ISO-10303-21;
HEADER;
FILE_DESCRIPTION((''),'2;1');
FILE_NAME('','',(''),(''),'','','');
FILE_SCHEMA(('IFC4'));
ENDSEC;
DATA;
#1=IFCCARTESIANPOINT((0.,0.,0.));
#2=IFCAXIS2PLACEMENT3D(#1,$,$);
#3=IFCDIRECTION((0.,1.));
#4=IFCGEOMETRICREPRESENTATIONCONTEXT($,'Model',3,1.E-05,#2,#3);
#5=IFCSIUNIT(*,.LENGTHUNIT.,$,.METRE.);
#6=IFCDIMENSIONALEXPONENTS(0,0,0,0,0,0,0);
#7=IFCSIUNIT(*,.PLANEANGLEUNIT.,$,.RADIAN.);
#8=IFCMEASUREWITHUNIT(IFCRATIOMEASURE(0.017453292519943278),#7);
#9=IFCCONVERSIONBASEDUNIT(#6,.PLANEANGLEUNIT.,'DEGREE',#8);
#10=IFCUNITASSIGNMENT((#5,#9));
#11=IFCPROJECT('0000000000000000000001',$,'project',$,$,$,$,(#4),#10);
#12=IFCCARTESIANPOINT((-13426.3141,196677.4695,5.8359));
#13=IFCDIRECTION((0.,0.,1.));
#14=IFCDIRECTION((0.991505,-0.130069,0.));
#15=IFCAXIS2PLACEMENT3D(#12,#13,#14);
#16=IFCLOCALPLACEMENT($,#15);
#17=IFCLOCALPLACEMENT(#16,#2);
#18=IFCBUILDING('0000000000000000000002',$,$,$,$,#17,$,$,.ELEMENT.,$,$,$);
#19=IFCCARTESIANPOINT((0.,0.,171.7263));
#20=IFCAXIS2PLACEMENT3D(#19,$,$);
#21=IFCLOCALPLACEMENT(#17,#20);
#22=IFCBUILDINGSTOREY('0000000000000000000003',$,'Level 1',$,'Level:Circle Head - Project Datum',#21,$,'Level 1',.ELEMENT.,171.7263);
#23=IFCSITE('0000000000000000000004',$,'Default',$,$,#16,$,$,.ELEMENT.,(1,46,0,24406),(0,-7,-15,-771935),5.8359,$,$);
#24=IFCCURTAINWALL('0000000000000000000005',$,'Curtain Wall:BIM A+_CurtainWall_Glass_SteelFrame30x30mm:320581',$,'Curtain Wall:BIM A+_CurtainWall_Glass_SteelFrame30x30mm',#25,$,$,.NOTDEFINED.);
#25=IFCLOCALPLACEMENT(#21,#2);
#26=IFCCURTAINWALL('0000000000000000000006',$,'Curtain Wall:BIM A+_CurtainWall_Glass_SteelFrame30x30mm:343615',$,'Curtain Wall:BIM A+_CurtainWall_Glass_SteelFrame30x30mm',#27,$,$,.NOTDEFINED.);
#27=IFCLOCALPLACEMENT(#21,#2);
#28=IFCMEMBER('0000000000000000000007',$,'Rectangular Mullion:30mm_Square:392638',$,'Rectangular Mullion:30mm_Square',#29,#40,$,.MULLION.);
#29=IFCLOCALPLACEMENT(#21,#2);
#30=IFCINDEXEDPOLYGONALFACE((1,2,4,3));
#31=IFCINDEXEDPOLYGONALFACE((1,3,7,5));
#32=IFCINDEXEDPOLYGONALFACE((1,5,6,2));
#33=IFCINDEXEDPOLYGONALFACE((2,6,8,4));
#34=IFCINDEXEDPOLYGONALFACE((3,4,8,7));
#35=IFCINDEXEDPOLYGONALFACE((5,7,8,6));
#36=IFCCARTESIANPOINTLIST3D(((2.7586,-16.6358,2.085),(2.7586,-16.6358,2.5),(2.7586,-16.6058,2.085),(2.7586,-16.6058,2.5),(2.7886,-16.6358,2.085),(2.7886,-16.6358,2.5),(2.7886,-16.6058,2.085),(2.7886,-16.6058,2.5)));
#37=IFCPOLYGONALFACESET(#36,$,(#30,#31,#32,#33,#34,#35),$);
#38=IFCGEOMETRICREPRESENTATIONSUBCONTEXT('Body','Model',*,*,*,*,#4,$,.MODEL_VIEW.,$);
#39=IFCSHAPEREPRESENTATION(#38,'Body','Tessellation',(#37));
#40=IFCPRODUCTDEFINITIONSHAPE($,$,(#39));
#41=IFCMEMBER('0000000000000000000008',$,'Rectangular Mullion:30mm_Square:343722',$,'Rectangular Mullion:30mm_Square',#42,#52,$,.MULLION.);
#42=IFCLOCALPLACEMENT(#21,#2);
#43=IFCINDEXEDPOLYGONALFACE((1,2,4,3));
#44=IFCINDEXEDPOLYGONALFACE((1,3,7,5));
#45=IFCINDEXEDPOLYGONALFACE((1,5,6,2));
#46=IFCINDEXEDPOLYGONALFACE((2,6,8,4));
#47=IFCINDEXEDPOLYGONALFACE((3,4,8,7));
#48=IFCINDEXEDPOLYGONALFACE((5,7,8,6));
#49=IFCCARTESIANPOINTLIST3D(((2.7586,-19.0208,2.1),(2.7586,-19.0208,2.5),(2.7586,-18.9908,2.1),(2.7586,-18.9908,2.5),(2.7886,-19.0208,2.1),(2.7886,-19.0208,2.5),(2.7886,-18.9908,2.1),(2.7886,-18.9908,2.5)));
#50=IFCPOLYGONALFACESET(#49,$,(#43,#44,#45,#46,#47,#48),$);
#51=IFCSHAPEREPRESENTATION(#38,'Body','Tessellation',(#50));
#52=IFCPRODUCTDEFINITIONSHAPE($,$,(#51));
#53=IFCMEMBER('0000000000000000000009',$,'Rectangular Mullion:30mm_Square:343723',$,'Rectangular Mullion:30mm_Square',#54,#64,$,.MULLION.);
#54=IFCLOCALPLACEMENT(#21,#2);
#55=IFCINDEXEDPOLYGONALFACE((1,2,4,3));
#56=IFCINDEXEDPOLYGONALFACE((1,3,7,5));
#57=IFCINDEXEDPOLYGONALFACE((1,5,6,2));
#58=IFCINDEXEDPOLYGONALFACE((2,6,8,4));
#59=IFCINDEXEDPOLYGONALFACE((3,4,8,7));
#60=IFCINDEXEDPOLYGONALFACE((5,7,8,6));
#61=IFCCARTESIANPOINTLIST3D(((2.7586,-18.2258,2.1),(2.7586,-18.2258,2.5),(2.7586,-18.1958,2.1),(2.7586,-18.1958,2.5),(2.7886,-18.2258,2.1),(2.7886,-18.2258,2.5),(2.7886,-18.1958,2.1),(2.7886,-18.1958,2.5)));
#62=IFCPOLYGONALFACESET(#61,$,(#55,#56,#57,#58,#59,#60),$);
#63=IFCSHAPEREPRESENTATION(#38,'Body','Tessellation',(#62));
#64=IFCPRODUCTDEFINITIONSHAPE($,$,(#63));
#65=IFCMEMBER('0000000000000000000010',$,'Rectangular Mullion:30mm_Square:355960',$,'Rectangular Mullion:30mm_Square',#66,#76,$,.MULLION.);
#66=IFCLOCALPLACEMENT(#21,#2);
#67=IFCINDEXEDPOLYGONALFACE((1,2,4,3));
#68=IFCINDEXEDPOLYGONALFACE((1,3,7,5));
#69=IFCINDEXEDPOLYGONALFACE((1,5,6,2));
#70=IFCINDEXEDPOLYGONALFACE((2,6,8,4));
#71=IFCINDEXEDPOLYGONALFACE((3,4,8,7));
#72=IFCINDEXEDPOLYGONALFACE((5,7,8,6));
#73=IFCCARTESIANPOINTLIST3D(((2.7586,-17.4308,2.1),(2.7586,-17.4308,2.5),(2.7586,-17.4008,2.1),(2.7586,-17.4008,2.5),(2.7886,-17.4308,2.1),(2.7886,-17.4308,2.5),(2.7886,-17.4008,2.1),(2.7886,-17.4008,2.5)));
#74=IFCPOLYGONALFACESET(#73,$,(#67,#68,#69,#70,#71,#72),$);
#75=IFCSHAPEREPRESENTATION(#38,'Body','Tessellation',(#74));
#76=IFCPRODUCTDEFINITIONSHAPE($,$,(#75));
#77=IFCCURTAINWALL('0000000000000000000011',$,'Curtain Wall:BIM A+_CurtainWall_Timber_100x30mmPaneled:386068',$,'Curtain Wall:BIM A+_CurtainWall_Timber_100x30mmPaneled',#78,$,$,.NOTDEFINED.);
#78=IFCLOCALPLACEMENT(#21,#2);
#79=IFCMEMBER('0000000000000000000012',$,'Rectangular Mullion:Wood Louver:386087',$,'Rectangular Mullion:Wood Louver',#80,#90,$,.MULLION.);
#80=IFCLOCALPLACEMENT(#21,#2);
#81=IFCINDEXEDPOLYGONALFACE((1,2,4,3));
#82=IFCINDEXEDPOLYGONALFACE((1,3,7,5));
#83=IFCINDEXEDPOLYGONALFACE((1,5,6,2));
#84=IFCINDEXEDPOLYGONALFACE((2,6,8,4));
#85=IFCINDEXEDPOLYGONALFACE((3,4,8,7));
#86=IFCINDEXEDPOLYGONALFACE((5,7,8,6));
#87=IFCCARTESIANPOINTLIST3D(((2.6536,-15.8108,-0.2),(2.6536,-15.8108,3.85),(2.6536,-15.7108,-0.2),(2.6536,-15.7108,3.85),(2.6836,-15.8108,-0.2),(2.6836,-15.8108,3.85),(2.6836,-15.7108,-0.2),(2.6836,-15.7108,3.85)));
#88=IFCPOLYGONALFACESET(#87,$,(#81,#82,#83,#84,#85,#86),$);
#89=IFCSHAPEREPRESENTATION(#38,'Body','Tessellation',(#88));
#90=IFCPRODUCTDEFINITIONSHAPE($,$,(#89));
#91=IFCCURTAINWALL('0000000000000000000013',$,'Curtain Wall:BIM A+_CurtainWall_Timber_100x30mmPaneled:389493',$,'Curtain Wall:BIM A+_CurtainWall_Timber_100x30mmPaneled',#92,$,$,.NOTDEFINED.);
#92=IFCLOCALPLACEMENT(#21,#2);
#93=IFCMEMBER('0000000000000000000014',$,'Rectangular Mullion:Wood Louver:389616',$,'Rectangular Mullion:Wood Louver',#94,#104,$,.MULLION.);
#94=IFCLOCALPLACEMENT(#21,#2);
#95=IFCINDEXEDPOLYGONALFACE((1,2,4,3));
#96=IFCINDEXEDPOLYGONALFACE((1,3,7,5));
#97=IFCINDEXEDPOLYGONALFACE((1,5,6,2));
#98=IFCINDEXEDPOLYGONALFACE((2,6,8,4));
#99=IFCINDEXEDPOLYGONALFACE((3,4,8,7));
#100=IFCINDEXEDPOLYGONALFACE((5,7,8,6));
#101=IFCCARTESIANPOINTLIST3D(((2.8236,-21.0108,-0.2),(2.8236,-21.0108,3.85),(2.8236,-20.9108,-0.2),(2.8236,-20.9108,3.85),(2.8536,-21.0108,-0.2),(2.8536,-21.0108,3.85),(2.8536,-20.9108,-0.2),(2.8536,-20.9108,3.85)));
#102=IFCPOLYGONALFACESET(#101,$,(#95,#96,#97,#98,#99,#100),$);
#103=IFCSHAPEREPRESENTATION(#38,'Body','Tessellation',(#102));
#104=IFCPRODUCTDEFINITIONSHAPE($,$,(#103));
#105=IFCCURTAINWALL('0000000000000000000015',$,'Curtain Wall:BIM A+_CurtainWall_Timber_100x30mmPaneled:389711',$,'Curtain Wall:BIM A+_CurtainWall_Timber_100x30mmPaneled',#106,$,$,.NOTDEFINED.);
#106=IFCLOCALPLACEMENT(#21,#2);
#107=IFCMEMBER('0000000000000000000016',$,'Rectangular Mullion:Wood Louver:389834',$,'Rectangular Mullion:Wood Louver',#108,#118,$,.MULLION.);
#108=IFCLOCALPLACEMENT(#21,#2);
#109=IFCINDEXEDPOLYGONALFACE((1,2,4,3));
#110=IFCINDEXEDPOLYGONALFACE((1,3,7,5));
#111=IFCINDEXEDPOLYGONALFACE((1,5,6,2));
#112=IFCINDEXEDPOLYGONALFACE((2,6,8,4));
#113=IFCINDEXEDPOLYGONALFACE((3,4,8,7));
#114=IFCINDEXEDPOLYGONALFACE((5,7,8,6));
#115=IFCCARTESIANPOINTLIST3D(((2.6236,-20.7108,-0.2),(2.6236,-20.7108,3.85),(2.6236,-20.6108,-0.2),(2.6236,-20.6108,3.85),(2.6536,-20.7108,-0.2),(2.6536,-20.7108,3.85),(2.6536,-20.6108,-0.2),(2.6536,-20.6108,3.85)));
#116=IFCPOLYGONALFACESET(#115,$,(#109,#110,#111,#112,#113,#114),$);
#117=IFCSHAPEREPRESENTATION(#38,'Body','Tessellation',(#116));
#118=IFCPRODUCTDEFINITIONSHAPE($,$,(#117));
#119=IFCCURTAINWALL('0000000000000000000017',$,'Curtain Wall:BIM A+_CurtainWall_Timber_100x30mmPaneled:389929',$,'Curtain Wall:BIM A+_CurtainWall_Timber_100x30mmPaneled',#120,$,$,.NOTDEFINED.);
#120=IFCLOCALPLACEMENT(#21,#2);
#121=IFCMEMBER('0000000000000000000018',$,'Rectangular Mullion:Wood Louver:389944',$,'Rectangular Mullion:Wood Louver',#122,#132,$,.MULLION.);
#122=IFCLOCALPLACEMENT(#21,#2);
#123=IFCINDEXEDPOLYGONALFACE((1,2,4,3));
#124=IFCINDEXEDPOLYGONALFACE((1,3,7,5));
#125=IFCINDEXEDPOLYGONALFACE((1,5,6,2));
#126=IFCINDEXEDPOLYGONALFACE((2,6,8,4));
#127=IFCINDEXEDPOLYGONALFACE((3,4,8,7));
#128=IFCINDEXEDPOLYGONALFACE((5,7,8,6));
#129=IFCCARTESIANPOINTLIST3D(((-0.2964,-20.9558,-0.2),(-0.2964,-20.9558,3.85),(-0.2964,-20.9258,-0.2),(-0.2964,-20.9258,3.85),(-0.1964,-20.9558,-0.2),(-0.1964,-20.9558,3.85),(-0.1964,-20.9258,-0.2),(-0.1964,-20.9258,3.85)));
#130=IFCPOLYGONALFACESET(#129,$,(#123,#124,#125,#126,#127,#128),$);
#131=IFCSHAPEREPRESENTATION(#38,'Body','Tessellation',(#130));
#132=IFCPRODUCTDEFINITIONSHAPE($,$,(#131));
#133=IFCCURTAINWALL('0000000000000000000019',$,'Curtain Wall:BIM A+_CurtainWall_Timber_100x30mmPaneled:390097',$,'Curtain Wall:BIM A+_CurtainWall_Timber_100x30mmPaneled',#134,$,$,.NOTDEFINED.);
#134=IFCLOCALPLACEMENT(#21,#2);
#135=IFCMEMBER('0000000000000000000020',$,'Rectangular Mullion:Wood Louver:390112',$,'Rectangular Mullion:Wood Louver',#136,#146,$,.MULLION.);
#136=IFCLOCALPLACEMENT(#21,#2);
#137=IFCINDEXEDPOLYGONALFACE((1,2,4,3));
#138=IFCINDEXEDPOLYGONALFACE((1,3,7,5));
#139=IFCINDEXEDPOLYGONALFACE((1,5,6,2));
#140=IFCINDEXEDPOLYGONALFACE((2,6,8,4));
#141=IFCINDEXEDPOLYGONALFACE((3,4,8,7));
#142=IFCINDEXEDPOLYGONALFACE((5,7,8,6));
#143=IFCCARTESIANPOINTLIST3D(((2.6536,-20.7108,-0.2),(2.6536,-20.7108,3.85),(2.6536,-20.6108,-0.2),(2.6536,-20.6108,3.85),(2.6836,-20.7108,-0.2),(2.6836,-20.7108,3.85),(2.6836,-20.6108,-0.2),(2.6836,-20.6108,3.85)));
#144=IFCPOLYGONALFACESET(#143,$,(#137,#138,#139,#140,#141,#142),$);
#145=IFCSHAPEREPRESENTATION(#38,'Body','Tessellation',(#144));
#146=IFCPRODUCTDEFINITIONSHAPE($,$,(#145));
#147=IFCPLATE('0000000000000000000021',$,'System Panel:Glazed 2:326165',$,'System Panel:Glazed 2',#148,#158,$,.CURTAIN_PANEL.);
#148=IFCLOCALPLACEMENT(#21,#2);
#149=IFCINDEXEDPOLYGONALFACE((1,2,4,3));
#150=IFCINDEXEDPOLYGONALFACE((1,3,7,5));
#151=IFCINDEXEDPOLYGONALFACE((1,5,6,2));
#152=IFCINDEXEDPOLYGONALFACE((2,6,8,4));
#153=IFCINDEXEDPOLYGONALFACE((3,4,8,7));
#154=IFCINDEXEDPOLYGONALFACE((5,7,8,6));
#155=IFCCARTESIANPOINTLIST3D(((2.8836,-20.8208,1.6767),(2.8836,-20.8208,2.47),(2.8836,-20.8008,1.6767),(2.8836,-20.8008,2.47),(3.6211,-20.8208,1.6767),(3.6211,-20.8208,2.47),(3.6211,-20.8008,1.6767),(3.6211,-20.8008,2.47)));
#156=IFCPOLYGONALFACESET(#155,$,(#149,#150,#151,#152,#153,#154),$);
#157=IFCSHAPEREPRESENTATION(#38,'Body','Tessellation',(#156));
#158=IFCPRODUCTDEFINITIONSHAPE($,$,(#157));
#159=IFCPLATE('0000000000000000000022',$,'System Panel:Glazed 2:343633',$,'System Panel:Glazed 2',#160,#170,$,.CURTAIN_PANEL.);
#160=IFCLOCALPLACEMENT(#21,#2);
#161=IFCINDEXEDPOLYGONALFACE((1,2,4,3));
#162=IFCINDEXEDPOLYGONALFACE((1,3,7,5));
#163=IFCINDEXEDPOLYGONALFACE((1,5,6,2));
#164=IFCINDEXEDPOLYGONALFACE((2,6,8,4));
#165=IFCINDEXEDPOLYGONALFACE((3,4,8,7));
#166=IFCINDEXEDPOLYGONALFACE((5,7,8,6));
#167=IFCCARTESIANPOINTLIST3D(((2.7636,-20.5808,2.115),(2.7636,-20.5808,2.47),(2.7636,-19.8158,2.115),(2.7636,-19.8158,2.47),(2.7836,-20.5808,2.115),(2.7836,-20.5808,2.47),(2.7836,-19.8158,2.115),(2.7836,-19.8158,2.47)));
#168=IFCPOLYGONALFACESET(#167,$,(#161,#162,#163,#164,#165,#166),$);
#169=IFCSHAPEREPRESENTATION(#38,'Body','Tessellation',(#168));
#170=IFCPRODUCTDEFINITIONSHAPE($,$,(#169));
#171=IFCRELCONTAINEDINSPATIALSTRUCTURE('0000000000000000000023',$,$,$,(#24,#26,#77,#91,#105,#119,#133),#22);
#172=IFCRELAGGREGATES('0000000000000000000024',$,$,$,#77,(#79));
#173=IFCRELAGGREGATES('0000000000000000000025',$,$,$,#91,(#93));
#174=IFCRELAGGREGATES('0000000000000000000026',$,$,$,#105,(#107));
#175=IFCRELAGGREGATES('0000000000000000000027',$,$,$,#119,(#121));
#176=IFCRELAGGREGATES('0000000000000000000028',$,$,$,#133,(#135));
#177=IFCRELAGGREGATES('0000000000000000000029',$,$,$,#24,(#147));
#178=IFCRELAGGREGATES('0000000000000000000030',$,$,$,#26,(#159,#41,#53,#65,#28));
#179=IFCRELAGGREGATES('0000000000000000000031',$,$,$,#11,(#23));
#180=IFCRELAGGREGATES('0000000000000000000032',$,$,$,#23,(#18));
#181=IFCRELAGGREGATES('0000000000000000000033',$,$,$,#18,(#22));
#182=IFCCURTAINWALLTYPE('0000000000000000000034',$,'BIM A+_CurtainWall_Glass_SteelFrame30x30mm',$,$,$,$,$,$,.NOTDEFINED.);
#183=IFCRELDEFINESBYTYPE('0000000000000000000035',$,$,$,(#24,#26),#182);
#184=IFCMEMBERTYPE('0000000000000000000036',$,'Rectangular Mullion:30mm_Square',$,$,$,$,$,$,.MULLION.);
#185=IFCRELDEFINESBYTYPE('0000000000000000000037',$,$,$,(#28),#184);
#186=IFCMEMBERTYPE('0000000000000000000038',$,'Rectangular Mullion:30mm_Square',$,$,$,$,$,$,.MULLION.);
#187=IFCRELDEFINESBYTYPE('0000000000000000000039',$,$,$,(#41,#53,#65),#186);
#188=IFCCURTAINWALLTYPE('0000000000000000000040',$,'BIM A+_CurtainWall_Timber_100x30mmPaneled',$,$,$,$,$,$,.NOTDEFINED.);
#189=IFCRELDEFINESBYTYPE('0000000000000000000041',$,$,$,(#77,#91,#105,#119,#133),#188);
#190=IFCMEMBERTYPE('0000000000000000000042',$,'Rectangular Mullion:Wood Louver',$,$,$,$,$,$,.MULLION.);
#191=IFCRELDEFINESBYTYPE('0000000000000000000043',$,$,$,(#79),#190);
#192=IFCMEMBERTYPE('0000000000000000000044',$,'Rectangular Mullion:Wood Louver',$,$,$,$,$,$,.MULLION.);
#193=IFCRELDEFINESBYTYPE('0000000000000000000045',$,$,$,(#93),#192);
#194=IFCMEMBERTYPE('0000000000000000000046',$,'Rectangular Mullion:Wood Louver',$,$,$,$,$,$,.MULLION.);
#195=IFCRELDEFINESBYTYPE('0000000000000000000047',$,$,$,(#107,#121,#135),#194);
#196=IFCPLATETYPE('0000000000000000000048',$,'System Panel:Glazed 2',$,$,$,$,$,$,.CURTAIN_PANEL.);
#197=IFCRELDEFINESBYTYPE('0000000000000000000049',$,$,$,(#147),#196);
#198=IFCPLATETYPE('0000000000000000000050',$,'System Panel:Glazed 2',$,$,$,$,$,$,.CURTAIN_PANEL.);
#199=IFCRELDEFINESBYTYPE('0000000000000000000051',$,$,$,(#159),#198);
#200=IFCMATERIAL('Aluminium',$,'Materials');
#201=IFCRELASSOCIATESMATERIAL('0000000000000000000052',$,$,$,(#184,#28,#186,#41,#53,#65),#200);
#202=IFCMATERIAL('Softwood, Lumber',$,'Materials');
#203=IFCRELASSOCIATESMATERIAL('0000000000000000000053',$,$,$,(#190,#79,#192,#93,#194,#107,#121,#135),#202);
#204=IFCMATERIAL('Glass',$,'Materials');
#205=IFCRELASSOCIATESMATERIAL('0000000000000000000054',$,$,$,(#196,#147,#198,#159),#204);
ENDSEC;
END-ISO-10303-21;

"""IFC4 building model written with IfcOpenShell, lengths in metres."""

from ifc_helpers import new_model, entity, si_unit, converted_unit, direction, frame, origin, place, context, subcontext, project, spatial, indexed_curve, outline, extrude, source, transform, mapped, material, type_object, type_shapes, element, aggregate, save


model = new_model("IFC4")

# Units and contexts
model_context = context("Model", 3, precision=1e-05, world=origin(), true_north=direction((0.0, 1.0)))
body_context = subcontext(model_context, "Body", "Model", "MODEL_VIEW")
ifc_project = project(units=[si_unit("LENGTHUNIT", "METRE"), converted_unit("PLANEANGLEUNIT", "DEGREE", entity("IfcRatioMeasure", 0.017453292519943278), si_unit("PLANEANGLEUNIT", "RADIAN"), dimensions=[0, 0, 0, 0, 0, 0, 0])], contexts=[model_context])

# Site, building, storey
site_placement = place(None, frame((-13426.3141, 196677.4695, 5.8359), z_axis=(0.0, 0.0, 1.0), x_axis=(0.991505, -0.130069, 0.0)))
site = spatial("IfcSite", under=ifc_project, at=site_placement, Name="Default", CompositionType="ELEMENT", RefLatitude=(1, 46, 0, 24406), RefLongitude=(0, -7, -15, -771935), RefElevation=5.8359)
building_placement = place(site_placement, origin())
building = spatial("IfcBuilding", under=site, at=building_placement, CompositionType="ELEMENT")
storey_placement = place(building_placement, frame((0.0, 0.0, 171.7263)))
storey = spatial("IfcBuildingStorey", under=building, at=storey_placement, Name="Level 1", ObjectType="Level:Circle Head - Project Datum", LongName="Level 1", CompositionType="ELEMENT", Elevation=171.7263)

# Curtain walls, members
curtain_wall_type_1 = type_object("IfcCurtainWallType", Name="BIM A+_CurtainWall_Glass_SteelFrame30x30mm", PredefinedType="NOTDEFINED")
curtain_wall_1_placement = place(storey_placement, frame((0.0, 0.0, -171.7263)))
curtain_wall_1 = element("IfcCurtainWall", 1, at=curtain_wall_1_placement, inside=storey, type_object=curtain_wall_type_1, Name="Curtain Wall:BIM A+_CurtainWall_Glass_SteelFrame30x30mm:320581", ObjectType="Curtain Wall:BIM A+_CurtainWall_Glass_SteelFrame30x30mm", PredefinedType="NOTDEFINED")
ifc_material_1 = material(Name="Aluminium", Category="Materials")
curtain_wall_2_placement = place(storey_placement, frame((0.0, 0.0, -171.7263)))
curtain_wall_2 = element("IfcCurtainWall", 2, at=curtain_wall_2_placement, inside=storey, type_object=curtain_wall_type_1, Name="Curtain Wall:BIM A+_CurtainWall_Glass_SteelFrame30x30mm:343615", ObjectType="Curtain Wall:BIM A+_CurtainWall_Glass_SteelFrame30x30mm", PredefinedType="NOTDEFINED")
member_type_1 = type_object("IfcMemberType", Name="Rectangular Mullion:30mm_Square", PredefinedType="MULLION", material=ifc_material_1)
shared_shape_1 = source(origin(), body_context, "Body", "SweptSolid", [
    extrude(outline(indexed_curve([(-0.015, -0.015), (0.015, -0.015), (0.015, 0.015), (-0.015, 0.015), (-0.015, -0.015)], self_intersect=False)), frame((0.0, 0.0, -0.415), z_axis=(0.0, 0.0, 1.0), x_axis=(0.0, -1.0, 0.0)), (0.0, 0.0, 1.0), 0.415),
])
type_shapes(member_type_1, [shared_shape_1])
member_1_placement = place(curtain_wall_2_placement, frame((2.7736, -16.6208, 173.8113), z_axis=(0.0, 0.0, -1.0), x_axis=(0.0, 1.0, 0.0)))
member_1 = element("IfcMember", 3, at=member_1_placement, type_object=member_type_1, material=ifc_material_1, Name="Rectangular Mullion:30mm_Square:392638", ObjectType="Rectangular Mullion:30mm_Square", PredefinedType="MULLION", context=body_context, shape_type="MappedRepresentation", body=[
    mapped(shared_shape_1, transform((0.0, 0.0, 0.0), scale=1.0)),
])
member_type_2 = type_object("IfcMemberType", Name="Rectangular Mullion:30mm_Square", PredefinedType="MULLION", material=ifc_material_1)
shared_shape_2 = source(origin(), body_context, "Body", "SweptSolid", [
    extrude(outline(indexed_curve([(-0.015, -0.015), (0.015, -0.015), (0.015, 0.015), (-0.015, 0.015), (-0.015, -0.015)], self_intersect=False)), frame((0.0, 0.0, -0.4), z_axis=(0.0, 0.0, 1.0), x_axis=(0.0, -1.0, 0.0)), (0.0, 0.0, 1.0), 0.4),
])
type_shapes(member_type_2, [shared_shape_2])
member_2_placement = place(curtain_wall_2_placement, frame((2.7736, -19.0058, 173.8263), z_axis=(0.0, 0.0, -1.0), x_axis=(0.0, 1.0, 0.0)))
member_2 = element("IfcMember", 4, at=member_2_placement, type_object=member_type_2, material=ifc_material_1, Name="Rectangular Mullion:30mm_Square:343722", ObjectType="Rectangular Mullion:30mm_Square", PredefinedType="MULLION", context=body_context, shape_type="MappedRepresentation", body=[
    mapped(shared_shape_2, transform((0.0, 0.0, 0.0), scale=1.0)),
])
member_3_placement = place(curtain_wall_2_placement, frame((2.7736, -18.2108, 173.8263), z_axis=(0.0, 0.0, -1.0), x_axis=(0.0, 1.0, 0.0)))
member_3 = element("IfcMember", 5, at=member_3_placement, type_object=member_type_2, material=ifc_material_1, Name="Rectangular Mullion:30mm_Square:343723", ObjectType="Rectangular Mullion:30mm_Square", PredefinedType="MULLION", context=body_context, shape_type="MappedRepresentation", body=[
    mapped(shared_shape_2, transform((0.0, 0.0, 0.0), scale=1.0)),
])
member_4_placement = place(curtain_wall_2_placement, frame((2.7736, -17.4158, 173.8263), z_axis=(0.0, 0.0, -1.0), x_axis=(0.0, 1.0, 0.0)))
member_4 = element("IfcMember", 6, at=member_4_placement, type_object=member_type_2, material=ifc_material_1, Name="Rectangular Mullion:30mm_Square:355960", ObjectType="Rectangular Mullion:30mm_Square", PredefinedType="MULLION", context=body_context, shape_type="MappedRepresentation", body=[
    mapped(shared_shape_2, transform((0.0, 0.0, 0.0), scale=1.0)),
])

# Curtain walls, members
curtain_wall_type_2 = type_object("IfcCurtainWallType", Name="BIM A+_CurtainWall_Timber_100x30mmPaneled", PredefinedType="NOTDEFINED")
curtain_wall_3_placement = place(storey_placement, frame((0.0, 0.0, -171.7263)))
curtain_wall_3 = element("IfcCurtainWall", 7, at=curtain_wall_3_placement, inside=storey, type_object=curtain_wall_type_2, Name="Curtain Wall:BIM A+_CurtainWall_Timber_100x30mmPaneled:386068", ObjectType="Curtain Wall:BIM A+_CurtainWall_Timber_100x30mmPaneled", PredefinedType="NOTDEFINED")
ifc_material_2 = material(Name="Softwood, Lumber", Category="Materials")
member_type_3 = type_object("IfcMemberType", Name="Rectangular Mullion:Wood Louver", PredefinedType="MULLION", material=ifc_material_2)
shared_shape_3 = source(origin(), body_context, "Body", "SweptSolid", [
    extrude(outline(indexed_curve([(-0.05, -0.015), (0.05, -0.015), (0.05, 0.015), (-0.05, 0.015), (-0.05, -0.015)], self_intersect=False)), frame((-0.015, -0.035, -4.05), z_axis=(0.0, 0.0, 1.0), x_axis=(0.0, -1.0, 0.0)), (0.0, 0.0, 1.0), 4.05),
])
type_shapes(member_type_3, [shared_shape_3])
member_5_placement = place(curtain_wall_3_placement, frame((2.6536, -15.7958, 175.5763), z_axis=(0.0, 0.0, 1.0), x_axis=(-1.0, 0.0, 0.0)))
member_5 = element("IfcMember", 8, at=member_5_placement, type_object=member_type_3, material=ifc_material_2, Name="Rectangular Mullion:Wood Louver:386087", ObjectType="Rectangular Mullion:Wood Louver", PredefinedType="MULLION", context=body_context, shape_type="MappedRepresentation", body=[
    mapped(shared_shape_3, transform((0.0, 0.0, 0.0), scale=1.0)),
])
aggregate(curtain_wall_3, [member_5])
curtain_wall_4_placement = place(storey_placement, frame((0.0, 0.0, -171.7263)))
curtain_wall_4 = element("IfcCurtainWall", 9, at=curtain_wall_4_placement, inside=storey, type_object=curtain_wall_type_2, Name="Curtain Wall:BIM A+_CurtainWall_Timber_100x30mmPaneled:389493", ObjectType="Curtain Wall:BIM A+_CurtainWall_Timber_100x30mmPaneled", PredefinedType="NOTDEFINED")
member_type_4 = type_object("IfcMemberType", Name="Rectangular Mullion:Wood Louver", PredefinedType="MULLION", material=ifc_material_2)
shared_shape_4 = source(origin(), body_context, "Body", "SweptSolid", [
    extrude(outline(indexed_curve([(-0.05, -0.015), (0.05, -0.015), (0.05, 0.015), (-0.05, 0.015), (-0.05, -0.015)], self_intersect=False)), frame((-0.015, -0.035, -4.05), z_axis=(0.0, 0.0, 1.0), x_axis=(0.0, -1.0, 0.0)), (0.0, 0.0, 1.0), 4.05),
])
type_shapes(member_type_4, [shared_shape_4])
member_6_placement = place(curtain_wall_4_placement, frame((2.8536, -20.9258, 175.5763)))
member_6 = element("IfcMember", 10, at=member_6_placement, type_object=member_type_4, material=ifc_material_2, Name="Rectangular Mullion:Wood Louver:389616", ObjectType="Rectangular Mullion:Wood Louver", PredefinedType="MULLION", context=body_context, shape_type="MappedRepresentation", body=[
    mapped(shared_shape_4, transform((0.0, 0.0, 0.0), scale=1.0)),
])
aggregate(curtain_wall_4, [member_6])
curtain_wall_5_placement = place(storey_placement, frame((0.0, 0.0, -171.7263)))
curtain_wall_5 = element("IfcCurtainWall", 11, at=curtain_wall_5_placement, inside=storey, type_object=curtain_wall_type_2, Name="Curtain Wall:BIM A+_CurtainWall_Timber_100x30mmPaneled:389711", ObjectType="Curtain Wall:BIM A+_CurtainWall_Timber_100x30mmPaneled", PredefinedType="NOTDEFINED")
member_type_5 = type_object("IfcMemberType", Name="Rectangular Mullion:Wood Louver", PredefinedType="MULLION", material=ifc_material_2)
shared_shape_5 = source(origin(), body_context, "Body", "SweptSolid", [
    extrude(outline(indexed_curve([(-0.05, -0.015), (0.05, -0.015), (0.05, 0.015), (-0.05, 0.015), (-0.05, -0.015)], self_intersect=False)), frame((-0.015, 0.035, -4.05), z_axis=(0.0, 0.0, 1.0), x_axis=(0.0, -1.0, 0.0)), (0.0, 0.0, 1.0), 4.05),
])
type_shapes(member_type_5, [shared_shape_5])
member_7_placement = place(curtain_wall_5_placement, frame((2.6536, -20.6958, 175.5763)))
member_7 = element("IfcMember", 12, at=member_7_placement, type_object=member_type_5, material=ifc_material_2, Name="Rectangular Mullion:Wood Louver:389834", ObjectType="Rectangular Mullion:Wood Louver", PredefinedType="MULLION", context=body_context, shape_type="MappedRepresentation", body=[
    mapped(shared_shape_5, transform((0.0, 0.0, 0.0), scale=1.0)),
])
aggregate(curtain_wall_5, [member_7])
curtain_wall_6_placement = place(storey_placement, frame((0.0, 0.0, -171.7263)))
curtain_wall_6 = element("IfcCurtainWall", 13, at=curtain_wall_6_placement, inside=storey, type_object=curtain_wall_type_2, Name="Curtain Wall:BIM A+_CurtainWall_Timber_100x30mmPaneled:389929", ObjectType="Curtain Wall:BIM A+_CurtainWall_Timber_100x30mmPaneled", PredefinedType="NOTDEFINED")
member_8_placement = place(curtain_wall_6_placement, frame((-0.2814, -20.9558, 175.5763), z_axis=(0.0, 0.0, 1.0), x_axis=(0.0, -1.0, 0.0)))
member_8 = element("IfcMember", 14, at=member_8_placement, type_object=member_type_5, material=ifc_material_2, Name="Rectangular Mullion:Wood Louver:389944", ObjectType="Rectangular Mullion:Wood Louver", PredefinedType="MULLION", context=body_context, shape_type="MappedRepresentation", body=[
    mapped(shared_shape_5, transform((0.0, 0.0, 0.0), scale=1.0)),
])
aggregate(curtain_wall_6, [member_8])
curtain_wall_7_placement = place(storey_placement, frame((0.0, 0.0, -171.7263)))
curtain_wall_7 = element("IfcCurtainWall", 15, at=curtain_wall_7_placement, inside=storey, type_object=curtain_wall_type_2, Name="Curtain Wall:BIM A+_CurtainWall_Timber_100x30mmPaneled:390097", ObjectType="Curtain Wall:BIM A+_CurtainWall_Timber_100x30mmPaneled", PredefinedType="NOTDEFINED")
member_9_placement = place(curtain_wall_7_placement, frame((2.6536, -20.6258, 175.5763), z_axis=(0.0, 0.0, 1.0), x_axis=(-1.0, 0.0, 0.0)))
member_9 = element("IfcMember", 16, at=member_9_placement, type_object=member_type_5, material=ifc_material_2, Name="Rectangular Mullion:Wood Louver:390112", ObjectType="Rectangular Mullion:Wood Louver", PredefinedType="MULLION", context=body_context, shape_type="MappedRepresentation", body=[
    mapped(shared_shape_5, transform((0.0, 0.0, 0.0), scale=1.0)),
])
aggregate(curtain_wall_7, [member_9])

# Plates
ifc_material_3 = material(Name="Glass", Category="Materials")
plate_type_1 = type_object("IfcPlateType", Name="System Panel:Glazed 2", PredefinedType="CURTAIN_PANEL", material=ifc_material_3)
shared_shape_6 = source(origin(), body_context, "Body", "SweptSolid", [
    extrude(outline(indexed_curve([(-0.01, -0.3688), (0.01, -0.3688), (0.01, 0.3688), (-0.01, 0.3688), (-0.01, -0.3688)], self_intersect=False)), frame((0.0, 0.0, 0.0), z_axis=(0.0, 0.0, 1.0), x_axis=(0.0, 1.0, 0.0)), (0.0, 0.0, 1.0), 0.7933),
])
type_shapes(plate_type_1, [shared_shape_6])
plate_1_placement = place(curtain_wall_1_placement, frame((3.2523, -20.8108, 173.4029)))
plate_1 = element("IfcPlate", 17, at=plate_1_placement, type_object=plate_type_1, material=ifc_material_3, Name="System Panel:Glazed 2:326165", ObjectType="System Panel:Glazed 2", PredefinedType="CURTAIN_PANEL", context=body_context, shape_type="MappedRepresentation", body=[
    mapped(shared_shape_6, transform((0.0, 0.0, 0.0), scale=1.0)),
])
aggregate(curtain_wall_1, [plate_1])
plate_type_2 = type_object("IfcPlateType", Name="System Panel:Glazed 2", PredefinedType="CURTAIN_PANEL", material=ifc_material_3)
shared_shape_7 = source(origin(), body_context, "Body", "SweptSolid", [
    extrude(outline(indexed_curve([(-0.01, -0.3825), (0.01, -0.3825), (0.01, 0.3825), (-0.01, 0.3825), (-0.01, -0.3825)], self_intersect=False)), frame((0.0, 0.0, 0.0), z_axis=(0.0, 0.0, 1.0), x_axis=(0.0, 1.0, 0.0)), (0.0, 0.0, 1.0), 0.355),
])
type_shapes(plate_type_2, [shared_shape_7])
plate_2_placement = place(curtain_wall_2_placement, frame((2.7736, -20.1983, 173.8413), z_axis=(0.0, 0.0, 1.0), x_axis=(0.0, 1.0, 0.0)))
plate_2 = element("IfcPlate", 18, at=plate_2_placement, type_object=plate_type_2, material=ifc_material_3, Name="System Panel:Glazed 2:343633", ObjectType="System Panel:Glazed 2", PredefinedType="CURTAIN_PANEL", context=body_context, shape_type="MappedRepresentation", body=[
    mapped(shared_shape_7, transform((0.0, 0.0, 0.0), scale=1.0)),
])
aggregate(curtain_wall_2, [plate_2, member_2, member_3, member_4, member_1])

save(model, "model.ifc")
